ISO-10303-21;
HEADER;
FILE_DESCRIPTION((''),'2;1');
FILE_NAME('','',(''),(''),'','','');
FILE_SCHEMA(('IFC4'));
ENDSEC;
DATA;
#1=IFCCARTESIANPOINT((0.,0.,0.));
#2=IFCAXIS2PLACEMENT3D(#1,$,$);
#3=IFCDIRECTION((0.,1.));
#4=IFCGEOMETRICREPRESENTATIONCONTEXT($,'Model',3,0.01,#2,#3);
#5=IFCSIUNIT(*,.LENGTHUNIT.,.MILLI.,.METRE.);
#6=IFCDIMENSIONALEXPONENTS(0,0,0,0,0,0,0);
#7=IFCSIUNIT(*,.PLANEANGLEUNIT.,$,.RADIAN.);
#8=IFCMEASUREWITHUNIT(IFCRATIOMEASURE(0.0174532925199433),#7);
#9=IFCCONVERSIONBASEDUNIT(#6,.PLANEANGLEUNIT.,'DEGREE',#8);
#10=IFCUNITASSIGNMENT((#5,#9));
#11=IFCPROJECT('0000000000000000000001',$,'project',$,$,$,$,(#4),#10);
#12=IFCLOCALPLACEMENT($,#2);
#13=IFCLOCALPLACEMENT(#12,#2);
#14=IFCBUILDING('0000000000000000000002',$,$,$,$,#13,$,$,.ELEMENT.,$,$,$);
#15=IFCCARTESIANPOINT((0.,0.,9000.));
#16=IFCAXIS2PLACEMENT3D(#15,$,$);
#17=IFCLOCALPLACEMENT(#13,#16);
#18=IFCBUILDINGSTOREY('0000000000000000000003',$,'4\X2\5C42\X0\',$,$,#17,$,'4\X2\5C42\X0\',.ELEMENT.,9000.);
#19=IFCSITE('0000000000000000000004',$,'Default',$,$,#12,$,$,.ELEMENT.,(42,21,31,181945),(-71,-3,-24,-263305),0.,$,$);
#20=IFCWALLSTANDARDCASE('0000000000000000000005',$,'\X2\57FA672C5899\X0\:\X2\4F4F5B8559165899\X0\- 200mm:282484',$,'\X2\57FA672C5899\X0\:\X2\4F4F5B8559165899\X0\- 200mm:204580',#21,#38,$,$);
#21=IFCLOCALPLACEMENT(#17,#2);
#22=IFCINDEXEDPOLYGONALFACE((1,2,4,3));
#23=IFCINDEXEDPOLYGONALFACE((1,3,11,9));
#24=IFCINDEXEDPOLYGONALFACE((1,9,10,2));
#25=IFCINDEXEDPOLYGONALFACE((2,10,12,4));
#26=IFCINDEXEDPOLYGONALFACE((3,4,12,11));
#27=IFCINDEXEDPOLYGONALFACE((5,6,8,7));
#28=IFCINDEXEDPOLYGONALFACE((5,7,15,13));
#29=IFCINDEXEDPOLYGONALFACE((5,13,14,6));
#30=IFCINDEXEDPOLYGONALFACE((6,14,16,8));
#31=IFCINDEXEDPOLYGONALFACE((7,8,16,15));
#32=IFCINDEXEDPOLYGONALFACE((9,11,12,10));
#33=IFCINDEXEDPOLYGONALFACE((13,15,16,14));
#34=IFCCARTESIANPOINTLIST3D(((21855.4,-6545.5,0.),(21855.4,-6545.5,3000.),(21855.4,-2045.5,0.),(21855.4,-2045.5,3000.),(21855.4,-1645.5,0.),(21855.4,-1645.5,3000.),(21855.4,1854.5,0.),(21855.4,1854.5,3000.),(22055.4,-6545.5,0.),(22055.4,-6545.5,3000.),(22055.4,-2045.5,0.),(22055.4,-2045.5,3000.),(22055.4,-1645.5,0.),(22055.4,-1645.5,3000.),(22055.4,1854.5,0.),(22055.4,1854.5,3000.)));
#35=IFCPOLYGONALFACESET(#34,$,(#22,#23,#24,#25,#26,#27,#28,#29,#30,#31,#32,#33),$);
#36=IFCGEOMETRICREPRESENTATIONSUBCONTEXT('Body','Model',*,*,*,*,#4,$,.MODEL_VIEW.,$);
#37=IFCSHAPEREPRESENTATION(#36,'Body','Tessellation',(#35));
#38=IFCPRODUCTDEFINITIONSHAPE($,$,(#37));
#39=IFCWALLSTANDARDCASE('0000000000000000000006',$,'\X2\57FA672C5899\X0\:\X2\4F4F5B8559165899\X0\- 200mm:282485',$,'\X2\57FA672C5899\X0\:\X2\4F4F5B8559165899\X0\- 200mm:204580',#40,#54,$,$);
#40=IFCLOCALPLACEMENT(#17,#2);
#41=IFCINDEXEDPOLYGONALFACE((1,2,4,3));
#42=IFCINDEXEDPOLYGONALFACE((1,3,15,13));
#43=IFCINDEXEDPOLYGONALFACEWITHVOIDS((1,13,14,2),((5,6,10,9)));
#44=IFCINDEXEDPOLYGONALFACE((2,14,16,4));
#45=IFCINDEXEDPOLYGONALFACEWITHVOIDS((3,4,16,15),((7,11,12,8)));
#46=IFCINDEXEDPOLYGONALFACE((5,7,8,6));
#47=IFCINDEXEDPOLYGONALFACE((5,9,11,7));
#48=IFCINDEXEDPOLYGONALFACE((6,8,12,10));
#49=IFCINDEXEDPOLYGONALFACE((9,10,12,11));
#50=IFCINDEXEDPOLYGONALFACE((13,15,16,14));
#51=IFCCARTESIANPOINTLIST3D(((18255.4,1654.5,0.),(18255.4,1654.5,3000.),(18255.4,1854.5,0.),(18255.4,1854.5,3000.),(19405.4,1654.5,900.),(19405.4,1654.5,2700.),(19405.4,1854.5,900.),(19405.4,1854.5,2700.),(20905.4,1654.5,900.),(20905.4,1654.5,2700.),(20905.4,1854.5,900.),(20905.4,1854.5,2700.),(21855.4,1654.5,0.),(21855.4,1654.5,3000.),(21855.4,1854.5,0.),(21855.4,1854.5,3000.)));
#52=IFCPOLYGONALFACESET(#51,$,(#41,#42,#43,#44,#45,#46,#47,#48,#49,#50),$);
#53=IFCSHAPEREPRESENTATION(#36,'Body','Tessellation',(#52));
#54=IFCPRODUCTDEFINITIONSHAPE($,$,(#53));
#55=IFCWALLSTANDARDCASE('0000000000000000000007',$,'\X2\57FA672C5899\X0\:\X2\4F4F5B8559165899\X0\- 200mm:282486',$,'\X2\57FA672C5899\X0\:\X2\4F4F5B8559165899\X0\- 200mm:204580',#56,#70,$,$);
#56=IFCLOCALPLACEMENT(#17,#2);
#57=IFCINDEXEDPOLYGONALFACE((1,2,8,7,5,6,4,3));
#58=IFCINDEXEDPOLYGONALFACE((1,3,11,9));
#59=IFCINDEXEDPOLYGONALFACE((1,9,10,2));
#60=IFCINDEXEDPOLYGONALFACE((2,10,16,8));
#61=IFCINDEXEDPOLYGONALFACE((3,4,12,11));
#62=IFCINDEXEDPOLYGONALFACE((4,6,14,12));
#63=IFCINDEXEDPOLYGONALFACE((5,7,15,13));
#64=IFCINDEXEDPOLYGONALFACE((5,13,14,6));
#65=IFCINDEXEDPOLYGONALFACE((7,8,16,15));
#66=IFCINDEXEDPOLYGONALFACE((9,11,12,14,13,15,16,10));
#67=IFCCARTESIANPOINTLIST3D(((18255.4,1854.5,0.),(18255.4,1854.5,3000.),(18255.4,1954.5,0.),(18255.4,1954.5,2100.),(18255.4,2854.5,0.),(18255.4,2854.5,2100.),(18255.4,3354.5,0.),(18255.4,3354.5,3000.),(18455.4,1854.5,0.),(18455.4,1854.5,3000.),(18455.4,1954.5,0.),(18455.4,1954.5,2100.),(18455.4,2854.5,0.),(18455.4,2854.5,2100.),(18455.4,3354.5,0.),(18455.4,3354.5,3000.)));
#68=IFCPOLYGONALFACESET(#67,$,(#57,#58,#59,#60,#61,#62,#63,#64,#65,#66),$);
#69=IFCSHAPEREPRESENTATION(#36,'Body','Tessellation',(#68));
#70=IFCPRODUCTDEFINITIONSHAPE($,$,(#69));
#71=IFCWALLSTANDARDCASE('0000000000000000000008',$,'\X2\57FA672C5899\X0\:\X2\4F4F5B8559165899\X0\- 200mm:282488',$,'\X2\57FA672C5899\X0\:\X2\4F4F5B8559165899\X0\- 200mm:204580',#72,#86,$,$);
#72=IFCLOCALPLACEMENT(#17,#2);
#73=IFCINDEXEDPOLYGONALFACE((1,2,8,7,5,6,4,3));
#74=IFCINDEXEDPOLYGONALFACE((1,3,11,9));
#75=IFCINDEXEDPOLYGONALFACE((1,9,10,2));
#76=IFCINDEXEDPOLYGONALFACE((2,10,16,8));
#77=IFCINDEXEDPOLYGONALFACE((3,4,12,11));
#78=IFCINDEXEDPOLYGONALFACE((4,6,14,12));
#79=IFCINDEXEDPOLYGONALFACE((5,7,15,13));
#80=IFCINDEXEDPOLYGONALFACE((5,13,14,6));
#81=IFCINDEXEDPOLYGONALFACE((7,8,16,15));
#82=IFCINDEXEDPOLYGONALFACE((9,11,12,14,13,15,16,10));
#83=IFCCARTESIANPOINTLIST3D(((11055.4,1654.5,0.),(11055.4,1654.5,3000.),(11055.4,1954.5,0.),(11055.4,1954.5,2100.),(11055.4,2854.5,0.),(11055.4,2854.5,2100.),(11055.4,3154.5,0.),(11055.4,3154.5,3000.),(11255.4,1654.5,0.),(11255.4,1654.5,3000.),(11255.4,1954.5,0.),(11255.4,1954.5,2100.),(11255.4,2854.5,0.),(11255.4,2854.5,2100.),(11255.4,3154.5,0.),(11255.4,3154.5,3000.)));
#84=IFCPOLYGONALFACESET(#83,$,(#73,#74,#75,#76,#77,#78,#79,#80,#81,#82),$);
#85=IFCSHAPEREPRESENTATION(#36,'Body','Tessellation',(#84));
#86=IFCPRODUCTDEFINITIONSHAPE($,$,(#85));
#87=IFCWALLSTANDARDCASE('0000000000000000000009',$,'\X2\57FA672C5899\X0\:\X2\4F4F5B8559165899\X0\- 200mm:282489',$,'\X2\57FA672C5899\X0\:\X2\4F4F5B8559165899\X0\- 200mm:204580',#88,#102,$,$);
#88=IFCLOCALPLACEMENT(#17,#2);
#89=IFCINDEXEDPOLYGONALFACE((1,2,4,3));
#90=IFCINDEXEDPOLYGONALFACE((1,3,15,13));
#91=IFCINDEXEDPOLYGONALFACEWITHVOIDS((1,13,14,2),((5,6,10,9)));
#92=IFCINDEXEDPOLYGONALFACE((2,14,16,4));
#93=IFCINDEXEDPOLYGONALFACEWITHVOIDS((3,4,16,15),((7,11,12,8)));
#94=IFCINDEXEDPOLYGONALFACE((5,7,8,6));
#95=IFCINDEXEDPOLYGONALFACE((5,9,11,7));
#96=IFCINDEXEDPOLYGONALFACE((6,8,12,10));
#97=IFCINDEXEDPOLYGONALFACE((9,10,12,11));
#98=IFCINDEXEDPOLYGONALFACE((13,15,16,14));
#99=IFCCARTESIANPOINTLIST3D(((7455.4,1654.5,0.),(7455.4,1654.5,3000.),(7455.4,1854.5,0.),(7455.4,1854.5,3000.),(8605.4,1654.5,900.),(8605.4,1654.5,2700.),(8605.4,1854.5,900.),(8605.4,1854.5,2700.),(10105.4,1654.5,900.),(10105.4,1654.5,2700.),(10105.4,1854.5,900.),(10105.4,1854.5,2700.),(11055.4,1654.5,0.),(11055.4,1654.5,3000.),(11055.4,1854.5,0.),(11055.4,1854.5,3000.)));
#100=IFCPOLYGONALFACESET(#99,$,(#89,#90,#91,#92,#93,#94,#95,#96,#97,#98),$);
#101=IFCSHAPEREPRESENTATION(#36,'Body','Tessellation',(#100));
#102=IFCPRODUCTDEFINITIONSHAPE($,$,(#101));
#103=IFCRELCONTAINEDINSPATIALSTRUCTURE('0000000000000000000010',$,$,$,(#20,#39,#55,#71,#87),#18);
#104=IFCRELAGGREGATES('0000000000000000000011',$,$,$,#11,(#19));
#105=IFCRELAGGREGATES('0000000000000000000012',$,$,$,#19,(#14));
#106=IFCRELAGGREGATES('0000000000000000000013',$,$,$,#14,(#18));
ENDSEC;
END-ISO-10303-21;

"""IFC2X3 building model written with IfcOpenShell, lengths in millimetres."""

from ifc_helpers import new_model, entity, si_unit, converted_unit, direction, frame, frame_2d, origin, place, context, subcontext, project, spatial, polyline, rectangle, extrude, clip, bounded_halfspace, element, save


model = new_model("IFC2X3")

# Units and contexts
model_context = context("Model", 3, precision=0.01, world=origin(), true_north=direction((0.0, 1.0)))
body_context = subcontext(model_context, "Body", "Model", "MODEL_VIEW")
ifc_project = project(units=[si_unit("LENGTHUNIT", "METRE", prefix="MILLI"), converted_unit("PLANEANGLEUNIT", "DEGREE", entity("IfcRatioMeasure", 0.0174532925199433), si_unit("PLANEANGLEUNIT", "RADIAN"), dimensions=[0, 0, 0, 0, 0, 0, 0])], contexts=[model_context])

# Site, building, storey
site_placement = place(None, origin())
site = spatial("IfcSite", under=ifc_project, at=site_placement, Name="Default", CompositionType="ELEMENT", RefLatitude=(42, 21, 31, 181945), RefLongitude=(-71, -3, -24, -263305), RefElevation=0.0)
building_placement = place(site_placement, origin())
building = spatial("IfcBuilding", under=site, at=building_placement, CompositionType="ELEMENT")
storey_placement = place(building_placement, frame((0.0, 0.0, 9000.0)))
storey = spatial("IfcBuildingStorey", under=building, at=storey_placement, Name="4层", LongName="4层", CompositionType="ELEMENT", Elevation=9000.0)

# Walls, openings
wall_1_placement = place(storey_placement, frame((21955.4, -6545.5, 0.0), z_axis=(0.0, 0.0, 1.0), x_axis=(0.0, 1.0, 0.0)))
wall_1 = element("IfcWallStandardCase", 1, at=wall_1_placement, inside=storey, Name="基本墙:住宅外墙- 200mm:282484", ObjectType="基本墙:住宅外墙- 200mm:204580", context=body_context, shape_type="Clipping", body=[
    clip(extrude(rectangle(XDim=8400.0, YDim=200.0, at=frame_2d((4200.0, 0.0), x_axis=(-1.0, 0.0))), origin(), (0.0, 0.0, 1.0), 3000.0), bounded_halfspace(frame((0.0, -100.0, 0.0), z_axis=(-1.0, 0.0, 0.0), x_axis=(0.0, 0.0, -1.0)), False, frame((0.0, -100.0, 0.0), z_axis=(-1.0, 0.0, 0.0), x_axis=(0.0, 0.0, -1.0)), polyline([(0.0, 0.0), (-3000.0, 0.0), (-3000.0, -200.0), (0.0, -200.0), (0.0, 0.0)]))),
])
opening_1_placement = place(storey_placement, frame((21955.4, -6545.5, 0.0), z_axis=(0.0, 0.0, 1.0), x_axis=(0.0, 1.0, 0.0)))
element("IfcOpeningElement", 2, at=opening_1_placement, cuts=wall_1, ObjectType="Opening", context=body_context, shape_type="SweptSolid", body=[
    extrude(rectangle(XDim=3000.0, YDim=200.0, at=frame_2d((0.0, 0.0), x_axis=(1.0, 0.0))), frame((4500.0, 0.0, 1500.0), z_axis=(1.0, 0.0, 0.0), x_axis=(0.0, 0.0, -1.0)), (0.0, 0.0, 1.0), 400.0),
])
wall_2_placement = place(storey_placement, frame((21855.4, 1754.5, 0.0), z_axis=(0.0, 0.0, 1.0), x_axis=(-1.0, 0.0, 0.0)))
wall_2 = element("IfcWallStandardCase", 3, at=wall_2_placement, inside=storey, Name="基本墙:住宅外墙- 200mm:282485", ObjectType="基本墙:住宅外墙- 200mm:204580", context=body_context, shape_type="SweptSolid", body=[
    extrude(rectangle(XDim=3600.0, YDim=200.0, at=frame_2d((1800.0, 0.0), x_axis=(-1.0, 0.0))), origin(), (0.0, 0.0, 1.0), 3000.0),
])
opening_2_placement = place(wall_2_placement, frame((2450.0, 100.0, 900.0)))
element("IfcOpeningElement", 4, at=opening_2_placement, cuts=wall_2, ObjectType="Opening", context=body_context, shape_type="SweptSolid", body=[
    extrude(rectangle(XDim=1800.0, YDim=1500.0, at=frame_2d((900.0, 750.0), x_axis=(1.0, 0.0))), frame((0.0, 0.0, 0.0), z_axis=(0.0, -1.0, 0.0), x_axis=(0.0, 0.0, 1.0)), (0.0, 0.0, 1.0), 200.0),
])
wall_3_placement = place(storey_placement, frame((18355.4, 1854.5, 0.0), z_axis=(0.0, 0.0, 1.0), x_axis=(0.0, 1.0, 0.0)))
wall_3 = element("IfcWallStandardCase", 5, at=wall_3_placement, inside=storey, Name="基本墙:住宅外墙- 200mm:282486", ObjectType="基本墙:住宅外墙- 200mm:204580", context=body_context, shape_type="SweptSolid", body=[
    extrude(rectangle(XDim=1500.0, YDim=200.0, at=frame_2d((750.0, 0.0), x_axis=(-1.0, 0.0))), origin(), (0.0, 0.0, 1.0), 3000.0),
])
opening_3_placement = place(wall_3_placement, frame((1000.0, 100.0, 0.0)))
element("IfcOpeningElement", 6, at=opening_3_placement, cuts=wall_3, ObjectType="Opening", context=body_context, shape_type="SweptSolid", body=[
    extrude(rectangle(XDim=2100.0, YDim=900.0, at=frame_2d((1050.0, 450.0), x_axis=(1.0, 0.0))), frame((0.0, 0.0, 0.0), z_axis=(0.0, -1.0, 0.0), x_axis=(0.0, 0.0, 1.0)), (0.0, 0.0, 1.0), 200.0),
])
wall_4_placement = place(storey_placement, frame((11155.4, 3154.5, 0.0), z_axis=(0.0, 0.0, 1.0), x_axis=(0.0, -1.0, 0.0)))
wall_4 = element("IfcWallStandardCase", 7, at=wall_4_placement, inside=storey, Name="基本墙:住宅外墙- 200mm:282488", ObjectType="基本墙:住宅外墙- 200mm:204580", context=body_context, shape_type="SweptSolid", body=[
    extrude(rectangle(XDim=1500.0, YDim=200.0, at=frame_2d((750.0, 0.0), x_axis=(-1.0, 0.0))), origin(), (0.0, 0.0, 1.0), 3000.0),
])
opening_4_placement = place(wall_4_placement, frame((1200.0, 100.0, 0.0)))
element("IfcOpeningElement", 8, at=opening_4_placement, cuts=wall_4, ObjectType="Opening", context=body_context, shape_type="SweptSolid", body=[
    extrude(rectangle(XDim=2100.0, YDim=900.0, at=frame_2d((1050.0, 450.0), x_axis=(1.0, 0.0))), frame((0.0, 0.0, 0.0), z_axis=(0.0, -1.0, 0.0), x_axis=(0.0, 0.0, 1.0)), (0.0, 0.0, 1.0), 200.0),
])
wall_5_placement = place(storey_placement, frame((11055.4, 1754.5, 0.0), z_axis=(0.0, 0.0, 1.0), x_axis=(-1.0, 0.0, 0.0)))
wall_5 = element("IfcWallStandardCase", 9, at=wall_5_placement, inside=storey, Name="基本墙:住宅外墙- 200mm:282489", ObjectType="基本墙:住宅外墙- 200mm:204580", context=body_context, shape_type="SweptSolid", body=[
    extrude(rectangle(XDim=3600.0, YDim=200.0, at=frame_2d((1800.0, 0.0), x_axis=(-1.0, 0.0))), origin(), (0.0, 0.0, 1.0), 3000.0),
])
opening_5_placement = place(wall_5_placement, frame((950.0, -100.0, 900.0)))
element("IfcOpeningElement", 10, at=opening_5_placement, cuts=wall_5, ObjectType="Opening", context=body_context, shape_type="SweptSolid", body=[
    extrude(rectangle(XDim=1800.0, YDim=1500.0, at=frame_2d((900.0, 750.0), x_axis=(1.0, 0.0))), frame((0.0, 0.0, 0.0), z_axis=(0.0, 1.0, 0.0), x_axis=(0.0, 0.0, 1.0)), (0.0, 0.0, 1.0), 200.0),
])

save(model, "model.ifc")
